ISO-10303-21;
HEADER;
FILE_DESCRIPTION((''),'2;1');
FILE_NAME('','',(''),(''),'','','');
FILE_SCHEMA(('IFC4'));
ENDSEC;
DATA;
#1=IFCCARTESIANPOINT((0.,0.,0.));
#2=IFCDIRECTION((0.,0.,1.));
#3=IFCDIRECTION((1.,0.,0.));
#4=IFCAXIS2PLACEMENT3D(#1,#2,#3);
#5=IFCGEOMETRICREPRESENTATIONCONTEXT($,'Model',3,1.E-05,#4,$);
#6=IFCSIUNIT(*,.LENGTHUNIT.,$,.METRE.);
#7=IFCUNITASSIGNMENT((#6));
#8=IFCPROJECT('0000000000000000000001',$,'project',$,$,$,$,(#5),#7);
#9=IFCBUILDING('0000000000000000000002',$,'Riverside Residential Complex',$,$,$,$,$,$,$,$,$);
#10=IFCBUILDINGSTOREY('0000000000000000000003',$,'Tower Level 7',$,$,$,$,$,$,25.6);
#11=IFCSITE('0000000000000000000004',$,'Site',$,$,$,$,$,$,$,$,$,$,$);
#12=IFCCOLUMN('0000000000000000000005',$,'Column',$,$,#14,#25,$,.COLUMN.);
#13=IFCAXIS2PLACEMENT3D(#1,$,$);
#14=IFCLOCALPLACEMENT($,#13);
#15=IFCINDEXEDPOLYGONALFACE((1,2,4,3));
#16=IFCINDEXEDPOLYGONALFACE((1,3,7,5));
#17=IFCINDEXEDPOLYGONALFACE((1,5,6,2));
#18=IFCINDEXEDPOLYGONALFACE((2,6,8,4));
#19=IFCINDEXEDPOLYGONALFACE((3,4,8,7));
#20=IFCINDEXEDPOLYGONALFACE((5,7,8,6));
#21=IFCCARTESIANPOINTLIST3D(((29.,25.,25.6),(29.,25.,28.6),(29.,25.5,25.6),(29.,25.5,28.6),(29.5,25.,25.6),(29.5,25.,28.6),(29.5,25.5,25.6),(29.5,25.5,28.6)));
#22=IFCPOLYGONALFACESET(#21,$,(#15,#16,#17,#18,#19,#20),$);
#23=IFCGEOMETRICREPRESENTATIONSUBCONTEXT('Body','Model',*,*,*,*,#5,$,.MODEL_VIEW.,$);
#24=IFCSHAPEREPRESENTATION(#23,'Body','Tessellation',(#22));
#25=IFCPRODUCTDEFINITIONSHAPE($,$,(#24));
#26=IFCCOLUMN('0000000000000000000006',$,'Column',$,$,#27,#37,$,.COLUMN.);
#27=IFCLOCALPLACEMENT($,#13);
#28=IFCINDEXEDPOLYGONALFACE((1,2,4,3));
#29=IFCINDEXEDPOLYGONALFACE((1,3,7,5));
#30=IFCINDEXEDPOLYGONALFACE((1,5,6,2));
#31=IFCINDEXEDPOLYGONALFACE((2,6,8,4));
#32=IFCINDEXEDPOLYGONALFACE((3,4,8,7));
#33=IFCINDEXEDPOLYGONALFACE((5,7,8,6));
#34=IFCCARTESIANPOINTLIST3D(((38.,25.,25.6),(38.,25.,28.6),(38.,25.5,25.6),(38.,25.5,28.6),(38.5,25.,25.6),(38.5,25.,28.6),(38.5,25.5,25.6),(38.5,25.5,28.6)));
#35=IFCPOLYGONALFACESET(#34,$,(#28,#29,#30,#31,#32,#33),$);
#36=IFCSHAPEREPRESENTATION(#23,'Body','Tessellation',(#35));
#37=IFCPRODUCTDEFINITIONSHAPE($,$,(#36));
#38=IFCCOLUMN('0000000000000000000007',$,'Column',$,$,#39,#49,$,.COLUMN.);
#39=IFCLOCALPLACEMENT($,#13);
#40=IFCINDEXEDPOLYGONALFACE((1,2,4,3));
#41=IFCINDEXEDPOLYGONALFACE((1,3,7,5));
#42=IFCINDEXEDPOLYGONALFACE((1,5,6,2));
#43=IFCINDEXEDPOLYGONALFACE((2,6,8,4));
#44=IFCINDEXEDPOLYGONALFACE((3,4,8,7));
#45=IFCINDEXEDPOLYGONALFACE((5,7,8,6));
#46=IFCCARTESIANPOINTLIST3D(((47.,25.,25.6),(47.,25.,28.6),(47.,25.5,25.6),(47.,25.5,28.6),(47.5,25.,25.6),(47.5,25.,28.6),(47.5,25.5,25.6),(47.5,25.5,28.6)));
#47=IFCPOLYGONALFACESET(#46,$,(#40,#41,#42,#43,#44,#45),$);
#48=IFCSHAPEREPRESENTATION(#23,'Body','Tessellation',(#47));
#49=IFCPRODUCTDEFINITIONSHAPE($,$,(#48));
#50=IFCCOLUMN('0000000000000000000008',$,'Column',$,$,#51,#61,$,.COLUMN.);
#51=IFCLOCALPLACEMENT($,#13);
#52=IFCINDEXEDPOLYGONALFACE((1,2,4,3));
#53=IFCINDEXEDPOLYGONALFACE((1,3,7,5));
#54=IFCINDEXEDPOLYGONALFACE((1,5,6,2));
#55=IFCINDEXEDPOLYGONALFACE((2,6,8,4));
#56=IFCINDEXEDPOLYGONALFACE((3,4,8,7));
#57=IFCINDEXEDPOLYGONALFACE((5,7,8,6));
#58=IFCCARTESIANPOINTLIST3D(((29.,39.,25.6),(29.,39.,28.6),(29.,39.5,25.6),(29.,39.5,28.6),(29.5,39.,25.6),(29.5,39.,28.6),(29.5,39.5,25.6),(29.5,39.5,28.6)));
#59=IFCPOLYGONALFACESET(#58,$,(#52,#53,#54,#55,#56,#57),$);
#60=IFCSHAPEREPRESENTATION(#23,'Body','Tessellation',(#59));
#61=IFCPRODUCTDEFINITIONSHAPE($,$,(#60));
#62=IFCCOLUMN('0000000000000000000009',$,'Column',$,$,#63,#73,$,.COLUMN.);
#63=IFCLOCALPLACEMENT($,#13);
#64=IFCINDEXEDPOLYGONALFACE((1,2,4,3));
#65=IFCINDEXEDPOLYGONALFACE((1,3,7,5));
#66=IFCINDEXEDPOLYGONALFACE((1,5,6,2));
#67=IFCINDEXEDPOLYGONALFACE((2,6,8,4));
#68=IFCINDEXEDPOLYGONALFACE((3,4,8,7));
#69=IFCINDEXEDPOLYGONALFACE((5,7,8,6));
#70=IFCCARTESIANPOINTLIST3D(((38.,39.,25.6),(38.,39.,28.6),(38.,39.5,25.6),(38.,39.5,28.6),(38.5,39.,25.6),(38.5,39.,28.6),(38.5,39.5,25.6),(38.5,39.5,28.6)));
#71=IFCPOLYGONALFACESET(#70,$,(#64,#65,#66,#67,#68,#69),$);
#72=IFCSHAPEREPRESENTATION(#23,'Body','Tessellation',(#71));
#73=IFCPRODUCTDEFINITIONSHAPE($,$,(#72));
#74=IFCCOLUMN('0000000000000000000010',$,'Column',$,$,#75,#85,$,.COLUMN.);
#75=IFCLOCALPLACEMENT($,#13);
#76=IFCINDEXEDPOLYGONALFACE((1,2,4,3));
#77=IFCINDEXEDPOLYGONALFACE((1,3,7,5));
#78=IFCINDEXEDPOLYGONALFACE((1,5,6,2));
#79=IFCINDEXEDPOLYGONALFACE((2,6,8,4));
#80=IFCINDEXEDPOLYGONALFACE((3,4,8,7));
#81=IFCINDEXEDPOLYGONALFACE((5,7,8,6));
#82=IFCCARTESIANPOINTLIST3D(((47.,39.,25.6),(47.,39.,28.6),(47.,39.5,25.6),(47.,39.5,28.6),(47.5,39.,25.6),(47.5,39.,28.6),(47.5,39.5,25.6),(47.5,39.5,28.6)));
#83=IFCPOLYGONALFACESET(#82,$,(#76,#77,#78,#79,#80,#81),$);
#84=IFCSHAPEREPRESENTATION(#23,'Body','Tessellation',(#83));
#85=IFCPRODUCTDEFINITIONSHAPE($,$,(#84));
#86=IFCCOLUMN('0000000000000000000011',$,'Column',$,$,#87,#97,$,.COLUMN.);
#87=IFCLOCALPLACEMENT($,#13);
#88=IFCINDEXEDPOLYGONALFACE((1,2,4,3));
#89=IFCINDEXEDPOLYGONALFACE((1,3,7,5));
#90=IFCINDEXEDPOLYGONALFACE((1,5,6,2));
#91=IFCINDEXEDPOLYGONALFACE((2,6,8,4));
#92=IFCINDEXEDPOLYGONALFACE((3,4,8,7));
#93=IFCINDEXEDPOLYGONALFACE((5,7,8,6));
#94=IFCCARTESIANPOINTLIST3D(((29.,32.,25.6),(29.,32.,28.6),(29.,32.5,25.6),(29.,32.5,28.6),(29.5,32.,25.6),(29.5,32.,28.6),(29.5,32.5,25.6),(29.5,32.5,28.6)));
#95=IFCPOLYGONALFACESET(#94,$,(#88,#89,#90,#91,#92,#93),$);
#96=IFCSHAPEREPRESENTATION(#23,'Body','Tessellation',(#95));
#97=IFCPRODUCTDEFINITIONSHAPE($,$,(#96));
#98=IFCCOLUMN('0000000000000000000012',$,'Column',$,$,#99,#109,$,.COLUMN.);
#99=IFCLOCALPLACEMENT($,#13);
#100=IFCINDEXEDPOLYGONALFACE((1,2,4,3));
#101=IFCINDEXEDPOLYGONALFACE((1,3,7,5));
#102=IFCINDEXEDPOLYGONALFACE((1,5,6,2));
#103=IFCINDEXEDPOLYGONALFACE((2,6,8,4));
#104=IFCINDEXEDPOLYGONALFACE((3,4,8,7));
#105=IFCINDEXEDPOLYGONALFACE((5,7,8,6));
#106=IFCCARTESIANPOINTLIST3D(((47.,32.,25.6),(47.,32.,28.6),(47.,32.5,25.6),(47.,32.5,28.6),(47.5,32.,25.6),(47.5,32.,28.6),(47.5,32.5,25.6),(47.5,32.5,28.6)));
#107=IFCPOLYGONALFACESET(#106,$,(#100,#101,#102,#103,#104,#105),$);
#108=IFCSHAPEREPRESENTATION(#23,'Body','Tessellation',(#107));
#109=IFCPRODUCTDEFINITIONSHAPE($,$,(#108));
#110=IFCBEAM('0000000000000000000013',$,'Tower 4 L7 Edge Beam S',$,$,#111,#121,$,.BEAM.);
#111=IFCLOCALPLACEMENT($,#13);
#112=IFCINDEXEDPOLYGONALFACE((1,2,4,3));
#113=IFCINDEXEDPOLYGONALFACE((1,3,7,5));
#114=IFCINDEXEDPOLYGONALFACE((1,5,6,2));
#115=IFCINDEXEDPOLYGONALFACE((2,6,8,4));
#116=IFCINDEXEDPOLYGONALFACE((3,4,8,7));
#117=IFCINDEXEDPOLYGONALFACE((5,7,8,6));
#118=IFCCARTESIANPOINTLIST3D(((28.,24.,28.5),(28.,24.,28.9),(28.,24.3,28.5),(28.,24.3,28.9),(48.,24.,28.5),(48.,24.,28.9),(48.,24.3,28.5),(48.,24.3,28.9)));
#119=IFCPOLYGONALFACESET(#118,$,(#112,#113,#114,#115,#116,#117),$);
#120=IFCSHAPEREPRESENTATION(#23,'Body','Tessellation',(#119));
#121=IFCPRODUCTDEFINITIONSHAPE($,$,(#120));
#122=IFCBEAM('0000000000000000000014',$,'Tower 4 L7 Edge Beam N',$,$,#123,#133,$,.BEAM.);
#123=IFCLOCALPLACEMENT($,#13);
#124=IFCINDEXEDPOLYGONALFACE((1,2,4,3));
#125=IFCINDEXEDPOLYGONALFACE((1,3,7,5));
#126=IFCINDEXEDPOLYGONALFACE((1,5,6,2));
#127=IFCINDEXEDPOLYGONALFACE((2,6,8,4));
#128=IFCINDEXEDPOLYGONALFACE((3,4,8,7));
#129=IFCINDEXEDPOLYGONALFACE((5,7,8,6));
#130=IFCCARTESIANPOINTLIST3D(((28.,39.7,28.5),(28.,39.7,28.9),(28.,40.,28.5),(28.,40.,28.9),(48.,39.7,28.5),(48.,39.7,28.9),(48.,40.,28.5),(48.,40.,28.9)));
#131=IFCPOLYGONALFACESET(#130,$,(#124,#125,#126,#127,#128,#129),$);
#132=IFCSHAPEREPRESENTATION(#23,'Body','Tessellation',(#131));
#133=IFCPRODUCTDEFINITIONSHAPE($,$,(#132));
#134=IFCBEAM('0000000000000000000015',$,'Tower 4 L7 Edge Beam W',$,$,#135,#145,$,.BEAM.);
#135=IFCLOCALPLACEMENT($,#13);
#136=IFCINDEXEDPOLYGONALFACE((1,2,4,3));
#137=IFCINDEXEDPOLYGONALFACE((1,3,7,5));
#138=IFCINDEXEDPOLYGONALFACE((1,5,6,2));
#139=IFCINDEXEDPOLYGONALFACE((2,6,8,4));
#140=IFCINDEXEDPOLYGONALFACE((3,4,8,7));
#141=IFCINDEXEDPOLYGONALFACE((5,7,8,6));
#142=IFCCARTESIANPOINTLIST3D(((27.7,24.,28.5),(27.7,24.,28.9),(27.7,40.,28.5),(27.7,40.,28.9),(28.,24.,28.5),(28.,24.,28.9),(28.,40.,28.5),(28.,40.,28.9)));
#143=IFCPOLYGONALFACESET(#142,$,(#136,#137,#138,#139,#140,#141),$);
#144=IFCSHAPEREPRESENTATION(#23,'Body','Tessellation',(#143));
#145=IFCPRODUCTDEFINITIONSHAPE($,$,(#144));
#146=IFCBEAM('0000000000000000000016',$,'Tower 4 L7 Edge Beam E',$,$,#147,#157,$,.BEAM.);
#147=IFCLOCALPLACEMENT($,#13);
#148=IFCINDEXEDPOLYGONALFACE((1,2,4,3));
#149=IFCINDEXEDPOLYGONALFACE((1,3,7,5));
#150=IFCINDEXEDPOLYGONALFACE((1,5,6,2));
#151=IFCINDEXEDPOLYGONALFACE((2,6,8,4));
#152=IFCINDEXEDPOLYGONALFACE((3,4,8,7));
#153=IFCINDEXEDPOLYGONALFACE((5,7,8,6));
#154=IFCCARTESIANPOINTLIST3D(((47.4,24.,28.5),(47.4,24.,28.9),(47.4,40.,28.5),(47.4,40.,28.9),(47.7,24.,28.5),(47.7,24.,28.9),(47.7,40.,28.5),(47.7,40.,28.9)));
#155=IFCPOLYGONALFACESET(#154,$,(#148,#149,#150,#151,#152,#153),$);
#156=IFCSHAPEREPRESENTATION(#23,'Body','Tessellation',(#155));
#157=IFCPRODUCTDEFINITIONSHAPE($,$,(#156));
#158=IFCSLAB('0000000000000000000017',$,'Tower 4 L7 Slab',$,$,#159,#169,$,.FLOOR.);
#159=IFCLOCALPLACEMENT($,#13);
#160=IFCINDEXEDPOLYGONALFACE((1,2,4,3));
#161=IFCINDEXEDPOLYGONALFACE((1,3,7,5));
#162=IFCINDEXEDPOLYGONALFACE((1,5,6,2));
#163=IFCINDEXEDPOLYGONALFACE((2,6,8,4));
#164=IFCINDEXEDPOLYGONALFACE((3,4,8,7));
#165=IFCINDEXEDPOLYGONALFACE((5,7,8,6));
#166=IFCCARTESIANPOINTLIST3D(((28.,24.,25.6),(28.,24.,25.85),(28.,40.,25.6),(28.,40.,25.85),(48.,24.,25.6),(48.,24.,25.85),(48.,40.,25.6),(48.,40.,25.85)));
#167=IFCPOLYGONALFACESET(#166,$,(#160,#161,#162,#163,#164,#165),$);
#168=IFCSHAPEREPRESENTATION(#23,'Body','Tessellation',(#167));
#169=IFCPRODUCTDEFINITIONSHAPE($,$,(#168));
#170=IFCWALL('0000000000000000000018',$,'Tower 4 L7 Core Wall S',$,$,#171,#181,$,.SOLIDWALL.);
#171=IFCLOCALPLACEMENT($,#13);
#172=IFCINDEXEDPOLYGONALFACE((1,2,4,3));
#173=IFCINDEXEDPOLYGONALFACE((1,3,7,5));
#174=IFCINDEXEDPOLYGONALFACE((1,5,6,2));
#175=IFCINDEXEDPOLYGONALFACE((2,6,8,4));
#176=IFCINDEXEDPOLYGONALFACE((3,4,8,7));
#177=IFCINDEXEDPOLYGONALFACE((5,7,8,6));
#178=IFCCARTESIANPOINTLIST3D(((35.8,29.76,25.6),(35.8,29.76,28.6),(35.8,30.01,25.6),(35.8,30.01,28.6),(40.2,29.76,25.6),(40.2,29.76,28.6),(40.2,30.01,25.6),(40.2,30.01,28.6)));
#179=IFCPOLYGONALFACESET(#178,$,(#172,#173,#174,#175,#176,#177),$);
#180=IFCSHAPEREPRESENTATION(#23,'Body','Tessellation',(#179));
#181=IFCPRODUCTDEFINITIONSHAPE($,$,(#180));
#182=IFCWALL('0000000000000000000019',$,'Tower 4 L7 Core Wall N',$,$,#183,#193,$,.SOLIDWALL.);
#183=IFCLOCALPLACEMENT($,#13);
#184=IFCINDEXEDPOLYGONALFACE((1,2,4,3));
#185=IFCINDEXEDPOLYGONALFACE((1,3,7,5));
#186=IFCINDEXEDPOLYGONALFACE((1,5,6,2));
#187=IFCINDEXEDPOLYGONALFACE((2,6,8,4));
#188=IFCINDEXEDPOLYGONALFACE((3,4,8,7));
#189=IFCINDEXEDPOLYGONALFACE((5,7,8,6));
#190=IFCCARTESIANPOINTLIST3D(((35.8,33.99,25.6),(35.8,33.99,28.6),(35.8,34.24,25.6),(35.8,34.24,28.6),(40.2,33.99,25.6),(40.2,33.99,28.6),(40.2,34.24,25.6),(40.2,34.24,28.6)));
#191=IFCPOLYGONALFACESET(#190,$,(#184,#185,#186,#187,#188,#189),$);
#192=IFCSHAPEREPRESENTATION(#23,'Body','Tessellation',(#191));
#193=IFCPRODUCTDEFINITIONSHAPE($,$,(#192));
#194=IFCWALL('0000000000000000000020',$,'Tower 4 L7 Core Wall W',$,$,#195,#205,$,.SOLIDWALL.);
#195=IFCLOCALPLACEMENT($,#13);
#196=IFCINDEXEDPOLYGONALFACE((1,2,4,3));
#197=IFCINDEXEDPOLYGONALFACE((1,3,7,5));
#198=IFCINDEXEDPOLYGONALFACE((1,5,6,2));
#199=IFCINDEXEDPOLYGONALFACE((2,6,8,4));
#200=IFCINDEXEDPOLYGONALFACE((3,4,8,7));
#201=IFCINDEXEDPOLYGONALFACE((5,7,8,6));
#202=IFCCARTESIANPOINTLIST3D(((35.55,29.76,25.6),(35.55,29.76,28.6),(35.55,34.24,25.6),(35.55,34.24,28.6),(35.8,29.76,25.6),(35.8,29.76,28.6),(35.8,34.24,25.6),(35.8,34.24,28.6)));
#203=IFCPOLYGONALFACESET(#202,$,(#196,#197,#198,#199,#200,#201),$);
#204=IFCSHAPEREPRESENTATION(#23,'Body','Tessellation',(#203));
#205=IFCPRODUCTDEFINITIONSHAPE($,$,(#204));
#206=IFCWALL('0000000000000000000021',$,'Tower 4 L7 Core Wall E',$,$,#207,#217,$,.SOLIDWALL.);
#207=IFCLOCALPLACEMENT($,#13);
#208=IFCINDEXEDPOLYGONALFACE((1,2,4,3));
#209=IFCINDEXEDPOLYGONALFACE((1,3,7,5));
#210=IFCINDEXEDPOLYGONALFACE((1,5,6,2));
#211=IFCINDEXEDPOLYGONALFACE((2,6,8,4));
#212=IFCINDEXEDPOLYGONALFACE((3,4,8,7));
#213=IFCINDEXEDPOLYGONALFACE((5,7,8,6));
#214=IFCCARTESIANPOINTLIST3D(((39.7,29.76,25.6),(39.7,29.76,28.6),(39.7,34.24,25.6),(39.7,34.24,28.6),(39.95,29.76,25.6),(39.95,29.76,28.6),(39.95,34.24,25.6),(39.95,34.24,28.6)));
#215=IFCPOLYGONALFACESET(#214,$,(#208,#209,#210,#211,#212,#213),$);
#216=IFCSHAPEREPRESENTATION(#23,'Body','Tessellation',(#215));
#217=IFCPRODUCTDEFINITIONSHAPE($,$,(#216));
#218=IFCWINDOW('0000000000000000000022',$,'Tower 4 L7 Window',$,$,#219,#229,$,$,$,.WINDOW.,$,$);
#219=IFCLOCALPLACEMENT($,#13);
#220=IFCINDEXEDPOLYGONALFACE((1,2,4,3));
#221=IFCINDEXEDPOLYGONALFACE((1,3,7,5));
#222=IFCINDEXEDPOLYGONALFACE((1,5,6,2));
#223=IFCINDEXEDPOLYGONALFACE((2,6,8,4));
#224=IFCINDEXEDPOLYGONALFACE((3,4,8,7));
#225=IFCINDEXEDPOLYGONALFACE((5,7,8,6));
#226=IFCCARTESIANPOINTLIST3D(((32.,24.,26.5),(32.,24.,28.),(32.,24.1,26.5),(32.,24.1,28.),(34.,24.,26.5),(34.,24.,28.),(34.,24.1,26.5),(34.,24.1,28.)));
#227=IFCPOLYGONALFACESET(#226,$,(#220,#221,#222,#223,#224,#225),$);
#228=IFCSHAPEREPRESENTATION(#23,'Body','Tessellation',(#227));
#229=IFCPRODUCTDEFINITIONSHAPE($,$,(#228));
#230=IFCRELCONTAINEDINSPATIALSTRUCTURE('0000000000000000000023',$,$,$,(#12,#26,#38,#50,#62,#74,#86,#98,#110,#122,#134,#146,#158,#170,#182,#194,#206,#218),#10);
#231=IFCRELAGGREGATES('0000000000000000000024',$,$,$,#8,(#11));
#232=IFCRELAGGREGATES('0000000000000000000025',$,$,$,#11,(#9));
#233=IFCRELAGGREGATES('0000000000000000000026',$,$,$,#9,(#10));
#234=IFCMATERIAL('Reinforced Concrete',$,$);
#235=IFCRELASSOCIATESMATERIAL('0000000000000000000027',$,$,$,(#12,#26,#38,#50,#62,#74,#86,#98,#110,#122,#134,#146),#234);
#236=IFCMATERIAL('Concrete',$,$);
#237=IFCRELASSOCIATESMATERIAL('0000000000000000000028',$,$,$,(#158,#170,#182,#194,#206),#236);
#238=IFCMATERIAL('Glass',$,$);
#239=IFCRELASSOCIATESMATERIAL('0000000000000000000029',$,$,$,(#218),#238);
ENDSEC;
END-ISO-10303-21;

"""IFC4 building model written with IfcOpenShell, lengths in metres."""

from ifc_helpers import new_model, si_unit, frame, origin_with_axes, place, context, subcontext, project, spatial, line, indexed_curve, outline, extrude, material, element, save


model = new_model("IFC4")

# Units and contexts
model_context = context("Model", 3, precision=1e-05, world=origin_with_axes())
body_context = subcontext(model_context, "Body", "Model", "MODEL_VIEW")
ifc_project = project(units=[si_unit("LENGTHUNIT", "METRE")], contexts=[model_context])

# Site, building, storey
site = spatial("IfcSite", under=ifc_project, Name="Site")
building = spatial("IfcBuilding", under=site, Name="Riverside Residential Complex")
storey = spatial("IfcBuildingStorey", under=building, Name="Tower Level 7", Elevation=25.6)

# Columns
ifc_material_1 = material(Name="Reinforced Concrete")
for number, where, z_axis, x_axis, name in (
    (1, (29.0, 25.0, 25.6), (0.0, 0.0, 1.0), (1.0, 0.0, 0.0), "Column"),
    (2, (38.0, 25.0, 25.6), (0.0, 0.0, 1.0), (1.0, 0.0, 0.0), "Column"),
    (3, (47.0, 25.0, 25.6), (0.0, 0.0, 1.0), (1.0, 0.0, 0.0), "Column"),
    (4, (29.0, 39.0, 25.6), (0.0, 0.0, 1.0), (1.0, 0.0, 0.0), "Column"),
    (5, (38.0, 39.0, 25.6), (0.0, 0.0, 1.0), (1.0, 0.0, 0.0), "Column"),
    (6, (47.0, 39.0, 25.6), (0.0, 0.0, 1.0), (1.0, 0.0, 0.0), "Column"),
    (7, (29.0, 32.0, 25.6), (0.0, 0.0, 1.0), (1.0, 0.0, 0.0), "Column"),
    (8, (47.0, 32.0, 25.6), (0.0, 0.0, 1.0), (1.0, 0.0, 0.0), "Column"),
):
    element("IfcColumn", number, at=place(None, frame(where, z_axis=z_axis, x_axis=x_axis)), inside=storey, material=ifc_material_1, Name=name, PredefinedType="COLUMN", context=body_context, shape_type="SweptSolid", body=[
        extrude(outline(indexed_curve([(0.0, 0.0), (0.5, 0.0), (0.5, 0.5), (0.0, 0.5)], segments=[line(1, 2, 3, 4, 1)])), origin_with_axes(), (0.0, 0.0, 1.0), 3.0),
    ])

# Beams
for number, where, z_axis, x_axis, name in (
    (9, (28.0, 24.0, 28.5), (0.0, 0.0, 1.0), (1.0, 0.0, 0.0), "Tower 4 L7 Edge Beam S"),
    (10, (28.0, 39.7, 28.5), (0.0, 0.0, 1.0), (1.0, 0.0, 0.0), "Tower 4 L7 Edge Beam N"),
):
    element("IfcBeam", number, at=place(None, frame(where, z_axis=z_axis, x_axis=x_axis)), inside=storey, material=ifc_material_1, Name=name, PredefinedType="BEAM", context=body_context, shape_type="SweptSolid", body=[
        extrude(outline(indexed_curve([(0.0, 0.0), (20.0, 0.0), (20.0, 0.3), (0.0, 0.3)], segments=[line(1, 2, 3, 4, 1)])), origin_with_axes(), (0.0, 0.0, 1.0), 0.4),
    ])
for number, where, z_axis, x_axis, name in (
    (11, (28.0, 24.0, 28.5), (0.0, 0.0, 1.0), (0.0, 1.0, 0.0), "Tower 4 L7 Edge Beam W"),
    (12, (47.7, 24.0, 28.5), (0.0, 0.0, 1.0), (0.0, 1.0, 0.0), "Tower 4 L7 Edge Beam E"),
):
    element("IfcBeam", number, at=place(None, frame(where, z_axis=z_axis, x_axis=x_axis)), inside=storey, material=ifc_material_1, Name=name, PredefinedType="BEAM", context=body_context, shape_type="SweptSolid", body=[
        extrude(outline(indexed_curve([(0.0, 0.0), (16.0, 0.0), (16.0, 0.3), (0.0, 0.3)], segments=[line(1, 2, 3, 4, 1)])), origin_with_axes(), (0.0, 0.0, 1.0), 0.4),
    ])

# Slab
ifc_material_2 = material(Name="Concrete")
slab_placement = place(None, frame((28.0, 24.0, 25.6), z_axis=(0.0, 0.0, 1.0), x_axis=(1.0, 0.0, 0.0)))
element("IfcSlab", 13, at=slab_placement, inside=storey, material=ifc_material_2, Name="Tower 4 L7 Slab", PredefinedType="FLOOR", context=body_context, shape_type="SweptSolid", body=[
    extrude(outline(indexed_curve([(0.0, 0.0), (20.0, 0.0), (20.0, 16.0), (0.0, 16.0)], segments=[line(1, 2, 3, 4, 1)])), origin_with_axes(), (0.0, 0.0, 1.0), 0.25),
])

# Walls
for number, where, z_axis, x_axis, name in (
    (14, (35.8, 29.76, 25.6), (0.0, 0.0, 1.0), (1.0, 0.0, 0.0), "Tower 4 L7 Core Wall S"),
    (15, (35.8, 33.99, 25.6), (0.0, 0.0, 1.0), (1.0, 0.0, 0.0), "Tower 4 L7 Core Wall N"),
):
    element("IfcWall", number, at=place(None, frame(where, z_axis=z_axis, x_axis=x_axis)), inside=storey, material=ifc_material_2, Name=name, PredefinedType="SOLIDWALL", context=body_context, shape_type="SweptSolid", body=[
        extrude(outline(indexed_curve([(0.0, 0.0), (4.4, 0.0), (4.4, 0.25), (0.0, 0.25)], segments=[line(1, 2, 3, 4, 1)])), origin_with_axes(), (0.0, 0.0, 1.0), 3.0),
    ])
for number, where, z_axis, x_axis, name in (
    (16, (35.8, 29.76, 25.6), (0.0, 0.0, 1.0), (0.0, 1.0, 0.0), "Tower 4 L7 Core Wall W"),
    (17, (39.95, 29.76, 25.6), (0.0, 0.0, 1.0), (0.0, 1.0, 0.0), "Tower 4 L7 Core Wall E"),
):
    element("IfcWall", number, at=place(None, frame(where, z_axis=z_axis, x_axis=x_axis)), inside=storey, material=ifc_material_2, Name=name, PredefinedType="SOLIDWALL", context=body_context, shape_type="SweptSolid", body=[
        extrude(outline(indexed_curve([(0.0, 0.0), (4.48, 0.0), (4.48, 0.25), (0.0, 0.25)], segments=[line(1, 2, 3, 4, 1)])), origin_with_axes(), (0.0, 0.0, 1.0), 3.0),
    ])

# Window
ifc_material_3 = material(Name="Glass")
for number, where, z_axis, x_axis, name in (
    (18, (32.0, 24.0, 26.5), (0.0, 0.0, 1.0), (1.0, 0.0, 0.0), "Tower 4 L7 Window"),
):
    element("IfcWindow", number, at=place(None, frame(where, z_axis=z_axis, x_axis=x_axis)), inside=storey, material=ifc_material_3, Name=name, PredefinedType="WINDOW", context=body_context, shape_type="SweptSolid", body=[
        extrude(outline(indexed_curve([(0.0, 0.0), (2.0, 0.0), (2.0, 0.1), (0.0, 0.1)], segments=[line(1, 2, 3, 4, 1)])), origin_with_axes(), (0.0, 0.0, 1.0), 1.5),
    ])

save(model, "model.ifc")
